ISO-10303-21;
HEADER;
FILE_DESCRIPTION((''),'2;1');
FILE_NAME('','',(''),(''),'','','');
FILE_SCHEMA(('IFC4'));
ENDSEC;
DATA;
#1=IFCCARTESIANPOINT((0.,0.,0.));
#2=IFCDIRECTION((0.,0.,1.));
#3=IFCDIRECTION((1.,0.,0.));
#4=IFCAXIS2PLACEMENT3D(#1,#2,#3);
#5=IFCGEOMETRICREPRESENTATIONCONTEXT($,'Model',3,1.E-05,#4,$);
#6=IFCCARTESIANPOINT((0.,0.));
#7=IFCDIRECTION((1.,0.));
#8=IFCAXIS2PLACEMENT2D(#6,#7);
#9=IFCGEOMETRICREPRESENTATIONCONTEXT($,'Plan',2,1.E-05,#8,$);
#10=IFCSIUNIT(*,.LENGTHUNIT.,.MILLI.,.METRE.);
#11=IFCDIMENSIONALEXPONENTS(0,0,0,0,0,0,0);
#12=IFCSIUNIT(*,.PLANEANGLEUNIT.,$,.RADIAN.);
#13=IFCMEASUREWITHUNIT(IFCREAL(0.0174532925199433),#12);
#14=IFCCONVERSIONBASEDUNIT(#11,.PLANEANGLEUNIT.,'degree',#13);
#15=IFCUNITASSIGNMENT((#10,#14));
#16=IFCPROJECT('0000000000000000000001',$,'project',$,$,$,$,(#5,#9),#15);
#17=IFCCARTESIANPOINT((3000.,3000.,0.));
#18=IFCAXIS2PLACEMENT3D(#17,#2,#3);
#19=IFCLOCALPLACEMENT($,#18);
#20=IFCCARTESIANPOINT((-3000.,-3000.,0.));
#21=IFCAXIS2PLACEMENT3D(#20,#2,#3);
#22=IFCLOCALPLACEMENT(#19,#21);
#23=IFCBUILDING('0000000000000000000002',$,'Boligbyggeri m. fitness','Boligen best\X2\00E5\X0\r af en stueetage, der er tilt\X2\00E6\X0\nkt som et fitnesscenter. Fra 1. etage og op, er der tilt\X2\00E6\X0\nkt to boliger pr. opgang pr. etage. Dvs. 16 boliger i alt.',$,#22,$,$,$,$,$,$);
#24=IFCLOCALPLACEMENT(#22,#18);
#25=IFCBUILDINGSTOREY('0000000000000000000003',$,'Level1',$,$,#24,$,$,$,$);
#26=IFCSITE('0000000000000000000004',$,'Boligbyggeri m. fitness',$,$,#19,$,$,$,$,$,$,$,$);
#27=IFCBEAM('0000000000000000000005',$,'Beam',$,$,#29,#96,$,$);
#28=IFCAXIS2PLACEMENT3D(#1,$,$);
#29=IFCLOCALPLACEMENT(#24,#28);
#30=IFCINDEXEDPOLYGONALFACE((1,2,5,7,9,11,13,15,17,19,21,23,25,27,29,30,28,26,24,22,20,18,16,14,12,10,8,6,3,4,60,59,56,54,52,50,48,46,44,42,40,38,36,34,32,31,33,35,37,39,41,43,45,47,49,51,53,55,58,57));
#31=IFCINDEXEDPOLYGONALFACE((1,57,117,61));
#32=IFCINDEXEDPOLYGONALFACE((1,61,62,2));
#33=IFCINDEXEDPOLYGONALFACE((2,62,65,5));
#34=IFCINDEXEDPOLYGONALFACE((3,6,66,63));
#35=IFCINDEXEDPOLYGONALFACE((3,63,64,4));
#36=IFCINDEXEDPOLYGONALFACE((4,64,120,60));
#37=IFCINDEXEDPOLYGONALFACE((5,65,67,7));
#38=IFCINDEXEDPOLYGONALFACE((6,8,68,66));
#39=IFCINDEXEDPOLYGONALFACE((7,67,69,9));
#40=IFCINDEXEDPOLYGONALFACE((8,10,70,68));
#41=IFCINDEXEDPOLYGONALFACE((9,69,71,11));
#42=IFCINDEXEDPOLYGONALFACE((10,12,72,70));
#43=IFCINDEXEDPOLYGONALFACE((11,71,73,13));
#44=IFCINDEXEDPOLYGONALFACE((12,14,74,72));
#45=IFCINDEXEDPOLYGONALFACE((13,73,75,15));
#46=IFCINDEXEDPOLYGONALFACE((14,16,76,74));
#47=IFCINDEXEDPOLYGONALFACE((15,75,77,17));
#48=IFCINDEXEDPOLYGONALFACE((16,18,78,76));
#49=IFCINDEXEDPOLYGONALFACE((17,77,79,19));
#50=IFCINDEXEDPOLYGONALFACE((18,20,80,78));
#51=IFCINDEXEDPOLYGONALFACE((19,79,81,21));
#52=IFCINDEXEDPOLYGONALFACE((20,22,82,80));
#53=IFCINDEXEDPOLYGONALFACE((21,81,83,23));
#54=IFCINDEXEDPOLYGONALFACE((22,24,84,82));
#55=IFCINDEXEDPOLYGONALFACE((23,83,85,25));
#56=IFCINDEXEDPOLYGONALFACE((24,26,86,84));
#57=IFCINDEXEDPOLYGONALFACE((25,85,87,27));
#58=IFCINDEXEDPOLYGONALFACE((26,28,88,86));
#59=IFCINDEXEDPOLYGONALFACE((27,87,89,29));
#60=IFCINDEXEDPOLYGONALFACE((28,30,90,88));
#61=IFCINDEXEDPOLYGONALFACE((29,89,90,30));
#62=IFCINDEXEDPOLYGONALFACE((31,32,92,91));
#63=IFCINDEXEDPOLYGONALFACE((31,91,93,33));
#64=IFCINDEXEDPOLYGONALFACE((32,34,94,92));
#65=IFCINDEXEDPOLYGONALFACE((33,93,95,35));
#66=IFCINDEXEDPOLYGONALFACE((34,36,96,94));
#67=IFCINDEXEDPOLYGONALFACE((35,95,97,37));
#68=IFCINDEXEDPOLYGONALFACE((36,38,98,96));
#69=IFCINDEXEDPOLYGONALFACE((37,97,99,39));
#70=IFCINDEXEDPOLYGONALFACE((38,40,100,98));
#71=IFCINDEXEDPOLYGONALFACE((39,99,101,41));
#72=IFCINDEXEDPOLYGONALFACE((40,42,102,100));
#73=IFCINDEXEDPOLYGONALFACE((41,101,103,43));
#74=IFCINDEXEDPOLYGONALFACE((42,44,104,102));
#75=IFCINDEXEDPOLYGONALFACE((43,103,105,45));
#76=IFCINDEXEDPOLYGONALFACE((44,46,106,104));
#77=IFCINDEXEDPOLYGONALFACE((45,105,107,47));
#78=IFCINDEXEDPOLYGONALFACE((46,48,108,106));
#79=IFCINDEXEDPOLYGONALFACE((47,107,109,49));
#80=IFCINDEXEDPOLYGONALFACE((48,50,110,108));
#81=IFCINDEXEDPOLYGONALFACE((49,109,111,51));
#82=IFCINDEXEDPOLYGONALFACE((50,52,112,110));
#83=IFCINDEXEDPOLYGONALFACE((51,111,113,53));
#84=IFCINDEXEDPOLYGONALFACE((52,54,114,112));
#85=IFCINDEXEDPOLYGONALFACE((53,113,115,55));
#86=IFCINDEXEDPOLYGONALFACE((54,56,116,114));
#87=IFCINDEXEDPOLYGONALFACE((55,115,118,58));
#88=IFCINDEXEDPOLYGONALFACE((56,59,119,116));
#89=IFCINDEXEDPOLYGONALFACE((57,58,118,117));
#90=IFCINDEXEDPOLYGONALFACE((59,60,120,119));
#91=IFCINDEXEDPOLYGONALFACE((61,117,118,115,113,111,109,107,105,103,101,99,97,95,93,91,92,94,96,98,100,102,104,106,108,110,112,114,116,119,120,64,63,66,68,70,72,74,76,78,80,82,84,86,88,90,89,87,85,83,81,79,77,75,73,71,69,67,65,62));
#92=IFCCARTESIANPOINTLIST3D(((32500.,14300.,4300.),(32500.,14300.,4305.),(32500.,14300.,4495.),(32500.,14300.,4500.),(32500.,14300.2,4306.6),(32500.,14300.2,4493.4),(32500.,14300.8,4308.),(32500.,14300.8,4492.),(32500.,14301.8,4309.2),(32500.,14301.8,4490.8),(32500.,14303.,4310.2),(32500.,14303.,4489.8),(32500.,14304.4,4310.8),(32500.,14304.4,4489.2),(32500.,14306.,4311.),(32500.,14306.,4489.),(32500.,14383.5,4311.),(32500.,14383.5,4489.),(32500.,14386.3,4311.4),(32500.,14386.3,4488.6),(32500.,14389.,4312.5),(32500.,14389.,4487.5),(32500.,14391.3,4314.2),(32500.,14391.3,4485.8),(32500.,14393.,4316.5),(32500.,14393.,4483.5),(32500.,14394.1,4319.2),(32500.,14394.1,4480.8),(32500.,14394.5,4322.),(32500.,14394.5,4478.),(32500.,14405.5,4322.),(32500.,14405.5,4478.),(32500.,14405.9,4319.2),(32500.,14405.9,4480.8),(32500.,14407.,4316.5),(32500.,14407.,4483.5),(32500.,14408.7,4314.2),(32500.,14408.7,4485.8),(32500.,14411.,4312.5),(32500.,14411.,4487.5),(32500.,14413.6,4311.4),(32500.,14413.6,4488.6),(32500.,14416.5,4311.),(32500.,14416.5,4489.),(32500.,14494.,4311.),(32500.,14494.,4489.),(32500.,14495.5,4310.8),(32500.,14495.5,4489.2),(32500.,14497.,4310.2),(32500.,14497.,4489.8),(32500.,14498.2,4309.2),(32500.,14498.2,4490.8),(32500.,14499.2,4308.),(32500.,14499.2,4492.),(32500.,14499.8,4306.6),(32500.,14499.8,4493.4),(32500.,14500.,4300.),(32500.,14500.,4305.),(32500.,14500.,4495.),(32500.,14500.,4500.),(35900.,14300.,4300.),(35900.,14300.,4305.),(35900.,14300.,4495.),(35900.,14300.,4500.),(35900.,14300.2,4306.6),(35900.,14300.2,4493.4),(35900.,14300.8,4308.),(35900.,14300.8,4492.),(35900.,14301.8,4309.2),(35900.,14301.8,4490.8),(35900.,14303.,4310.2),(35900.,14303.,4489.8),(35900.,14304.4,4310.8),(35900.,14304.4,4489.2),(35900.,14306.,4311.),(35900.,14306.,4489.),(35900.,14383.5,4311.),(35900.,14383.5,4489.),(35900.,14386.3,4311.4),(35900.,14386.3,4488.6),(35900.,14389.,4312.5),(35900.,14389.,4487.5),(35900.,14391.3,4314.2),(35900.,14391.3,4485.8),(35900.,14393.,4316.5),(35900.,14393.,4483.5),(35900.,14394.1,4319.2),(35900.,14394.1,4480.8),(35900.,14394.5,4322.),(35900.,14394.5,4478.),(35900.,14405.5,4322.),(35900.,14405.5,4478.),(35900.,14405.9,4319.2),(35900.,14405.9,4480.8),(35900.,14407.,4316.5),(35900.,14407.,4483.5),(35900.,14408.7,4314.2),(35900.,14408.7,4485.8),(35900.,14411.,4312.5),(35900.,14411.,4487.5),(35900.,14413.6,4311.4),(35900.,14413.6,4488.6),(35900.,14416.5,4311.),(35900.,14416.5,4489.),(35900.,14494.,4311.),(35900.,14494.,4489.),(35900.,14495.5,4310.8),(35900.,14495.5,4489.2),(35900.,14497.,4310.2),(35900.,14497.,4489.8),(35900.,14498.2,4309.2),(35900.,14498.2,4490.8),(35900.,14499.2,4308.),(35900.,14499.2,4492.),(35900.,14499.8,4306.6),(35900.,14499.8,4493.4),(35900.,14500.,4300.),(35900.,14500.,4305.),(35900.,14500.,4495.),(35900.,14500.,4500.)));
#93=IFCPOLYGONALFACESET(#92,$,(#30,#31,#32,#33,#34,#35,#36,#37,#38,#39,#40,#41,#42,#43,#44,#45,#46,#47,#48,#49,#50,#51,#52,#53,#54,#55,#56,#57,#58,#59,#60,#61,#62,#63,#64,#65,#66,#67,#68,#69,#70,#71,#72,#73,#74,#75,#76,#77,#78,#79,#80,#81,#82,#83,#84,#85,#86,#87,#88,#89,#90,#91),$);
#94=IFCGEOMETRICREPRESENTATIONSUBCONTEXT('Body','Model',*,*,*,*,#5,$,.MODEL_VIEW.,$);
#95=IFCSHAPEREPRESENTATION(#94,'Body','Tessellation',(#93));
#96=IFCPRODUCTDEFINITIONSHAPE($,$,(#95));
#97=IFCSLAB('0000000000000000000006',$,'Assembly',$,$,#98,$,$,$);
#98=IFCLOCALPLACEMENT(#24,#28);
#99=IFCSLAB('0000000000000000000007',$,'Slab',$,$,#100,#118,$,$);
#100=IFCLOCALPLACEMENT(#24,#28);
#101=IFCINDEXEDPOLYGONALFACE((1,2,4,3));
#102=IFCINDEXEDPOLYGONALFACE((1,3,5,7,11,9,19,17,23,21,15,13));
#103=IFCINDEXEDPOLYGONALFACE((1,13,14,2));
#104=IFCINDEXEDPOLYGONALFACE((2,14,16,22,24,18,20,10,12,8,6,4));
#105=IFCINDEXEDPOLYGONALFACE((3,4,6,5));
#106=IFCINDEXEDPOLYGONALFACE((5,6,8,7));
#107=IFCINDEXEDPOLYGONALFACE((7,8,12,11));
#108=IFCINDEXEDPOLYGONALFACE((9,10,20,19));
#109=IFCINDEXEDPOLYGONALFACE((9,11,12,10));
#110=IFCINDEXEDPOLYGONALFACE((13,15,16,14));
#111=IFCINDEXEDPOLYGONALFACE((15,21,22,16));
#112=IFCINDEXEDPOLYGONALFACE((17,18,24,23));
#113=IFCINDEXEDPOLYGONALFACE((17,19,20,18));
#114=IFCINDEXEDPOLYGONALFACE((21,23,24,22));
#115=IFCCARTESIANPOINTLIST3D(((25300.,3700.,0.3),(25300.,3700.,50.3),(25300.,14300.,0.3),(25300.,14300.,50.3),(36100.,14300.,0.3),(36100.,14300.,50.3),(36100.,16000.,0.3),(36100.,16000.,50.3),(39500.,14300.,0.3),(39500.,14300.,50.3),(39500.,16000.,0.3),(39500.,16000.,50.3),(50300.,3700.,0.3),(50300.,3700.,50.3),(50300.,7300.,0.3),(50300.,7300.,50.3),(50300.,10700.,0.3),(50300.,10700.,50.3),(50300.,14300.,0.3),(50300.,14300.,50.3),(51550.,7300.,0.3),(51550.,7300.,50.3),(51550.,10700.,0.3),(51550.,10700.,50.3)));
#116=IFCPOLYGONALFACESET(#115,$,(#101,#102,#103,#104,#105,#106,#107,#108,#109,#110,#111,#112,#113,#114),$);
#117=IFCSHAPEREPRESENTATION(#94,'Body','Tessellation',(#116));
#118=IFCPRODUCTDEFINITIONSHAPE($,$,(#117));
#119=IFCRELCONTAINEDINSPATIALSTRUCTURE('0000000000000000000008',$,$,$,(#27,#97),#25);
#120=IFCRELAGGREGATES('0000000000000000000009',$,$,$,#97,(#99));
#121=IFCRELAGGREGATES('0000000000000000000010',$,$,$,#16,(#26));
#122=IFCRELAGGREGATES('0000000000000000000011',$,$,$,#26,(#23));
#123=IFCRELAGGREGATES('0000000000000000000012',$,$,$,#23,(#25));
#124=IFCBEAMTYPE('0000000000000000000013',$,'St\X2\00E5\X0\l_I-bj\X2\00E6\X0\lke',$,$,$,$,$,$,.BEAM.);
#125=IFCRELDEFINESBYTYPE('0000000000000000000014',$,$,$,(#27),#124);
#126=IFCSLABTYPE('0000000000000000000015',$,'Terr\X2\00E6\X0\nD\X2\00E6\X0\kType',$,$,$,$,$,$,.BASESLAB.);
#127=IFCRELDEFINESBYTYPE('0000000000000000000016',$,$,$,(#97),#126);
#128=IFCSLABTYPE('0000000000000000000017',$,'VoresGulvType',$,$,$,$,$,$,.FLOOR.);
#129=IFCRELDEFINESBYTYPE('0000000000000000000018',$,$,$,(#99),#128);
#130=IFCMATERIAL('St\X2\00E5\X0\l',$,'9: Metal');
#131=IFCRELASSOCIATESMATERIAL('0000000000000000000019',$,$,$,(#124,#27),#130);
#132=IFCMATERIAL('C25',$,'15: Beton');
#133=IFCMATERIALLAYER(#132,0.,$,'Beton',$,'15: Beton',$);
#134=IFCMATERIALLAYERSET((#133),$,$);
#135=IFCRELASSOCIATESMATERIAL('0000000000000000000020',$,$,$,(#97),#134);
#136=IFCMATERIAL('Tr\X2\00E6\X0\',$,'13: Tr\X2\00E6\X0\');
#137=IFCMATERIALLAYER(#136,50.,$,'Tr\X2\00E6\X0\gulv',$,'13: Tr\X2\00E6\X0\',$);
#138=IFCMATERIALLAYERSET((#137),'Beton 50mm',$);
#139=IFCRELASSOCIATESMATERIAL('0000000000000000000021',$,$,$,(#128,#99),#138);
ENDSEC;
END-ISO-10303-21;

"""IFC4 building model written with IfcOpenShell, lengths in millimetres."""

from ifc_helpers import new_model, entity, si_unit, converted_unit, frame, origin_with_axes, origin_2d_with_axis, place, context, subcontext, project, spatial, line, indexed_curve, i_section, outline, extrude, material, layer, layer_set, layer_usage, material_profile, profile_set, profile_usage, type_object, element, aggregate, save


model = new_model("IFC4")

# Units and contexts
model_context = context("Model", 3, precision=1e-05, world=origin_with_axes())
plan_context = context("Plan", 2, precision=1e-05, world=origin_2d_with_axis())
body_context = subcontext(model_context, "Body", "Model", "MODEL_VIEW")
ifc_project = project(units=[si_unit("LENGTHUNIT", "METRE", prefix="MILLI"), converted_unit("PLANEANGLEUNIT", "degree", entity("IfcReal", 0.0174532925199433), si_unit("PLANEANGLEUNIT", "RADIAN"), dimensions=[0, 0, 0, 0, 0, 0, 0])], contexts=[model_context, plan_context])

# Site, building, storey
site_placement = place(None, frame((3000.0, 3000.0, 0.0), z_axis=(0.0, 0.0, 1.0), x_axis=(1.0, 0.0, 0.0)))
site = spatial("IfcSite", under=ifc_project, at=site_placement, Name="Boligbyggeri m. fitness")
building_placement = place(site_placement, frame((-3000.0, -3000.0, 0.0), z_axis=(0.0, 0.0, 1.0), x_axis=(1.0, 0.0, 0.0)))
building = spatial("IfcBuilding", under=site, at=building_placement, Name="Boligbyggeri m. fitness", Description="Boligen består af en stueetage, der er tiltænkt som et fitnesscenter. Fra 1. etage og op, er der tiltænkt to boliger pr. opgang pr. etage. Dvs. 16 boliger i alt.")
storey_placement = place(building_placement, frame((3000.0, 3000.0, 0.0), z_axis=(0.0, 0.0, 1.0), x_axis=(1.0, 0.0, 0.0)))
storey = spatial("IfcBuildingStorey", under=building, at=storey_placement, Name="Level1")

# Shared definitions
ifc_material_1 = material(Name="C25", Category="15: Beton")

# Beam
ifc_material_2 = material(Name="Stål", Category="9: Metal")
ifc_material_profile_1 = material_profile(ifc_material_2, i_section(OverallWidth=200.0, OverallDepth=200.0, WebThickness=11.0, FlangeThickness=11.0, FilletRadius=11.0, FlangeEdgeRadius=6.0), Name="Stål", Category="9: Metal")
ifc_profile_set_1 = profile_set([ifc_material_profile_1], Name="NY_I-Profil")
beam_type = type_object("IfcBeamType", Name="Stål_I-bjælke", PredefinedType="BEAM", material=ifc_profile_set_1)
ifc_profile_usage_1 = profile_usage(ifc_profile_set_1, cardinal=7)
beam_1_placement = place(storey_placement, frame((32500.0, 14500.0, 4500.0), z_axis=(1.0, 0.0, 0.0), x_axis=(0.0, 1.0, 0.0)))
element("IfcBeam", 1, at=beam_1_placement, inside=storey, type_object=beam_type, material=ifc_profile_usage_1, Name="Beam", context=body_context, shape_type="SweptSolid", body=[
    extrude(i_section(OverallWidth=200.0, OverallDepth=200.0, WebThickness=11.0, FlangeThickness=11.0, FilletRadius=11.0, FlangeEdgeRadius=6.0), frame((-100.0, -100.0, 0.0), z_axis=(0.0, 0.0, 1.0), x_axis=(1.0, 0.0, 0.0)), (0.0, 0.0, 1.0), 3400.0),
])

# Slabs
ifc_layer_1 = layer(ifc_material_1, 0.0, Name="Beton", Category="15: Beton")
ifc_layer_set_1 = layer_set([ifc_layer_1])
ifc_layer_usage_1 = layer_usage(ifc_layer_set_1, "AXIS3", "POSITIVE", 0.0)
slab_type_1 = type_object("IfcSlabType", Name="TerrænDækType", PredefinedType="BASESLAB")
slab_1_placement = place(storey_placement, frame((25300.0, 3700.0, 0.3), z_axis=(0.0, 0.0, 1.0), x_axis=(1.0, 0.0, 0.0)))
slab_1 = element("IfcSlab", 2, at=slab_1_placement, inside=storey, type_object=slab_type_1, material=ifc_layer_usage_1, Name="Assembly")
ifc_material_3 = material(Name="Træ", Category="13: Træ")
ifc_layer_2 = layer(ifc_material_3, 50.0, Name="Trægulv", Category="13: Træ")
ifc_layer_set_2 = layer_set([ifc_layer_2], Name="Beton 50mm")
ifc_layer_usage_2 = layer_usage(ifc_layer_set_2, "AXIS3", "POSITIVE", 0.0)
slab_type_2 = type_object("IfcSlabType", Name="VoresGulvType", PredefinedType="FLOOR", material=ifc_layer_set_2)
slab_2_placement = place(slab_1_placement, frame((0.0, 0.0, 0.0), z_axis=(0.0, 0.0, 1.0), x_axis=(1.0, 0.0, 0.0)))
slab_2 = element("IfcSlab", 3, at=slab_2_placement, type_object=slab_type_2, material=ifc_layer_usage_2, Name="Slab", context=body_context, shape_type="SweptSolid", body=[
    extrude(outline(indexed_curve([(25000.0, 0.0), (25000.0, 10600.0), (14200.0, 10600.0), (14200.0, 12300.0), (10800.0, 12300.0), (10800.0, 10600.0), (0.0, 10600.0), (0.0, 0.0), (26250.0, 7000.0), (25000.0, 7000.0), (25000.0, 3600.0), (26250.0, 3600.0)], segments=[line(11, 1), line(1, 8), line(8, 7), line(7, 6), line(6, 5), line(5, 4), line(4, 3), line(3, 2), line(2, 10), line(10, 9), line(9, 12), line(12, 11)], self_intersect=False)), None, (0.0, 0.0, 1.0), 50.0),
])
aggregate(slab_1, [slab_2])

save(model, "model.ifc")
